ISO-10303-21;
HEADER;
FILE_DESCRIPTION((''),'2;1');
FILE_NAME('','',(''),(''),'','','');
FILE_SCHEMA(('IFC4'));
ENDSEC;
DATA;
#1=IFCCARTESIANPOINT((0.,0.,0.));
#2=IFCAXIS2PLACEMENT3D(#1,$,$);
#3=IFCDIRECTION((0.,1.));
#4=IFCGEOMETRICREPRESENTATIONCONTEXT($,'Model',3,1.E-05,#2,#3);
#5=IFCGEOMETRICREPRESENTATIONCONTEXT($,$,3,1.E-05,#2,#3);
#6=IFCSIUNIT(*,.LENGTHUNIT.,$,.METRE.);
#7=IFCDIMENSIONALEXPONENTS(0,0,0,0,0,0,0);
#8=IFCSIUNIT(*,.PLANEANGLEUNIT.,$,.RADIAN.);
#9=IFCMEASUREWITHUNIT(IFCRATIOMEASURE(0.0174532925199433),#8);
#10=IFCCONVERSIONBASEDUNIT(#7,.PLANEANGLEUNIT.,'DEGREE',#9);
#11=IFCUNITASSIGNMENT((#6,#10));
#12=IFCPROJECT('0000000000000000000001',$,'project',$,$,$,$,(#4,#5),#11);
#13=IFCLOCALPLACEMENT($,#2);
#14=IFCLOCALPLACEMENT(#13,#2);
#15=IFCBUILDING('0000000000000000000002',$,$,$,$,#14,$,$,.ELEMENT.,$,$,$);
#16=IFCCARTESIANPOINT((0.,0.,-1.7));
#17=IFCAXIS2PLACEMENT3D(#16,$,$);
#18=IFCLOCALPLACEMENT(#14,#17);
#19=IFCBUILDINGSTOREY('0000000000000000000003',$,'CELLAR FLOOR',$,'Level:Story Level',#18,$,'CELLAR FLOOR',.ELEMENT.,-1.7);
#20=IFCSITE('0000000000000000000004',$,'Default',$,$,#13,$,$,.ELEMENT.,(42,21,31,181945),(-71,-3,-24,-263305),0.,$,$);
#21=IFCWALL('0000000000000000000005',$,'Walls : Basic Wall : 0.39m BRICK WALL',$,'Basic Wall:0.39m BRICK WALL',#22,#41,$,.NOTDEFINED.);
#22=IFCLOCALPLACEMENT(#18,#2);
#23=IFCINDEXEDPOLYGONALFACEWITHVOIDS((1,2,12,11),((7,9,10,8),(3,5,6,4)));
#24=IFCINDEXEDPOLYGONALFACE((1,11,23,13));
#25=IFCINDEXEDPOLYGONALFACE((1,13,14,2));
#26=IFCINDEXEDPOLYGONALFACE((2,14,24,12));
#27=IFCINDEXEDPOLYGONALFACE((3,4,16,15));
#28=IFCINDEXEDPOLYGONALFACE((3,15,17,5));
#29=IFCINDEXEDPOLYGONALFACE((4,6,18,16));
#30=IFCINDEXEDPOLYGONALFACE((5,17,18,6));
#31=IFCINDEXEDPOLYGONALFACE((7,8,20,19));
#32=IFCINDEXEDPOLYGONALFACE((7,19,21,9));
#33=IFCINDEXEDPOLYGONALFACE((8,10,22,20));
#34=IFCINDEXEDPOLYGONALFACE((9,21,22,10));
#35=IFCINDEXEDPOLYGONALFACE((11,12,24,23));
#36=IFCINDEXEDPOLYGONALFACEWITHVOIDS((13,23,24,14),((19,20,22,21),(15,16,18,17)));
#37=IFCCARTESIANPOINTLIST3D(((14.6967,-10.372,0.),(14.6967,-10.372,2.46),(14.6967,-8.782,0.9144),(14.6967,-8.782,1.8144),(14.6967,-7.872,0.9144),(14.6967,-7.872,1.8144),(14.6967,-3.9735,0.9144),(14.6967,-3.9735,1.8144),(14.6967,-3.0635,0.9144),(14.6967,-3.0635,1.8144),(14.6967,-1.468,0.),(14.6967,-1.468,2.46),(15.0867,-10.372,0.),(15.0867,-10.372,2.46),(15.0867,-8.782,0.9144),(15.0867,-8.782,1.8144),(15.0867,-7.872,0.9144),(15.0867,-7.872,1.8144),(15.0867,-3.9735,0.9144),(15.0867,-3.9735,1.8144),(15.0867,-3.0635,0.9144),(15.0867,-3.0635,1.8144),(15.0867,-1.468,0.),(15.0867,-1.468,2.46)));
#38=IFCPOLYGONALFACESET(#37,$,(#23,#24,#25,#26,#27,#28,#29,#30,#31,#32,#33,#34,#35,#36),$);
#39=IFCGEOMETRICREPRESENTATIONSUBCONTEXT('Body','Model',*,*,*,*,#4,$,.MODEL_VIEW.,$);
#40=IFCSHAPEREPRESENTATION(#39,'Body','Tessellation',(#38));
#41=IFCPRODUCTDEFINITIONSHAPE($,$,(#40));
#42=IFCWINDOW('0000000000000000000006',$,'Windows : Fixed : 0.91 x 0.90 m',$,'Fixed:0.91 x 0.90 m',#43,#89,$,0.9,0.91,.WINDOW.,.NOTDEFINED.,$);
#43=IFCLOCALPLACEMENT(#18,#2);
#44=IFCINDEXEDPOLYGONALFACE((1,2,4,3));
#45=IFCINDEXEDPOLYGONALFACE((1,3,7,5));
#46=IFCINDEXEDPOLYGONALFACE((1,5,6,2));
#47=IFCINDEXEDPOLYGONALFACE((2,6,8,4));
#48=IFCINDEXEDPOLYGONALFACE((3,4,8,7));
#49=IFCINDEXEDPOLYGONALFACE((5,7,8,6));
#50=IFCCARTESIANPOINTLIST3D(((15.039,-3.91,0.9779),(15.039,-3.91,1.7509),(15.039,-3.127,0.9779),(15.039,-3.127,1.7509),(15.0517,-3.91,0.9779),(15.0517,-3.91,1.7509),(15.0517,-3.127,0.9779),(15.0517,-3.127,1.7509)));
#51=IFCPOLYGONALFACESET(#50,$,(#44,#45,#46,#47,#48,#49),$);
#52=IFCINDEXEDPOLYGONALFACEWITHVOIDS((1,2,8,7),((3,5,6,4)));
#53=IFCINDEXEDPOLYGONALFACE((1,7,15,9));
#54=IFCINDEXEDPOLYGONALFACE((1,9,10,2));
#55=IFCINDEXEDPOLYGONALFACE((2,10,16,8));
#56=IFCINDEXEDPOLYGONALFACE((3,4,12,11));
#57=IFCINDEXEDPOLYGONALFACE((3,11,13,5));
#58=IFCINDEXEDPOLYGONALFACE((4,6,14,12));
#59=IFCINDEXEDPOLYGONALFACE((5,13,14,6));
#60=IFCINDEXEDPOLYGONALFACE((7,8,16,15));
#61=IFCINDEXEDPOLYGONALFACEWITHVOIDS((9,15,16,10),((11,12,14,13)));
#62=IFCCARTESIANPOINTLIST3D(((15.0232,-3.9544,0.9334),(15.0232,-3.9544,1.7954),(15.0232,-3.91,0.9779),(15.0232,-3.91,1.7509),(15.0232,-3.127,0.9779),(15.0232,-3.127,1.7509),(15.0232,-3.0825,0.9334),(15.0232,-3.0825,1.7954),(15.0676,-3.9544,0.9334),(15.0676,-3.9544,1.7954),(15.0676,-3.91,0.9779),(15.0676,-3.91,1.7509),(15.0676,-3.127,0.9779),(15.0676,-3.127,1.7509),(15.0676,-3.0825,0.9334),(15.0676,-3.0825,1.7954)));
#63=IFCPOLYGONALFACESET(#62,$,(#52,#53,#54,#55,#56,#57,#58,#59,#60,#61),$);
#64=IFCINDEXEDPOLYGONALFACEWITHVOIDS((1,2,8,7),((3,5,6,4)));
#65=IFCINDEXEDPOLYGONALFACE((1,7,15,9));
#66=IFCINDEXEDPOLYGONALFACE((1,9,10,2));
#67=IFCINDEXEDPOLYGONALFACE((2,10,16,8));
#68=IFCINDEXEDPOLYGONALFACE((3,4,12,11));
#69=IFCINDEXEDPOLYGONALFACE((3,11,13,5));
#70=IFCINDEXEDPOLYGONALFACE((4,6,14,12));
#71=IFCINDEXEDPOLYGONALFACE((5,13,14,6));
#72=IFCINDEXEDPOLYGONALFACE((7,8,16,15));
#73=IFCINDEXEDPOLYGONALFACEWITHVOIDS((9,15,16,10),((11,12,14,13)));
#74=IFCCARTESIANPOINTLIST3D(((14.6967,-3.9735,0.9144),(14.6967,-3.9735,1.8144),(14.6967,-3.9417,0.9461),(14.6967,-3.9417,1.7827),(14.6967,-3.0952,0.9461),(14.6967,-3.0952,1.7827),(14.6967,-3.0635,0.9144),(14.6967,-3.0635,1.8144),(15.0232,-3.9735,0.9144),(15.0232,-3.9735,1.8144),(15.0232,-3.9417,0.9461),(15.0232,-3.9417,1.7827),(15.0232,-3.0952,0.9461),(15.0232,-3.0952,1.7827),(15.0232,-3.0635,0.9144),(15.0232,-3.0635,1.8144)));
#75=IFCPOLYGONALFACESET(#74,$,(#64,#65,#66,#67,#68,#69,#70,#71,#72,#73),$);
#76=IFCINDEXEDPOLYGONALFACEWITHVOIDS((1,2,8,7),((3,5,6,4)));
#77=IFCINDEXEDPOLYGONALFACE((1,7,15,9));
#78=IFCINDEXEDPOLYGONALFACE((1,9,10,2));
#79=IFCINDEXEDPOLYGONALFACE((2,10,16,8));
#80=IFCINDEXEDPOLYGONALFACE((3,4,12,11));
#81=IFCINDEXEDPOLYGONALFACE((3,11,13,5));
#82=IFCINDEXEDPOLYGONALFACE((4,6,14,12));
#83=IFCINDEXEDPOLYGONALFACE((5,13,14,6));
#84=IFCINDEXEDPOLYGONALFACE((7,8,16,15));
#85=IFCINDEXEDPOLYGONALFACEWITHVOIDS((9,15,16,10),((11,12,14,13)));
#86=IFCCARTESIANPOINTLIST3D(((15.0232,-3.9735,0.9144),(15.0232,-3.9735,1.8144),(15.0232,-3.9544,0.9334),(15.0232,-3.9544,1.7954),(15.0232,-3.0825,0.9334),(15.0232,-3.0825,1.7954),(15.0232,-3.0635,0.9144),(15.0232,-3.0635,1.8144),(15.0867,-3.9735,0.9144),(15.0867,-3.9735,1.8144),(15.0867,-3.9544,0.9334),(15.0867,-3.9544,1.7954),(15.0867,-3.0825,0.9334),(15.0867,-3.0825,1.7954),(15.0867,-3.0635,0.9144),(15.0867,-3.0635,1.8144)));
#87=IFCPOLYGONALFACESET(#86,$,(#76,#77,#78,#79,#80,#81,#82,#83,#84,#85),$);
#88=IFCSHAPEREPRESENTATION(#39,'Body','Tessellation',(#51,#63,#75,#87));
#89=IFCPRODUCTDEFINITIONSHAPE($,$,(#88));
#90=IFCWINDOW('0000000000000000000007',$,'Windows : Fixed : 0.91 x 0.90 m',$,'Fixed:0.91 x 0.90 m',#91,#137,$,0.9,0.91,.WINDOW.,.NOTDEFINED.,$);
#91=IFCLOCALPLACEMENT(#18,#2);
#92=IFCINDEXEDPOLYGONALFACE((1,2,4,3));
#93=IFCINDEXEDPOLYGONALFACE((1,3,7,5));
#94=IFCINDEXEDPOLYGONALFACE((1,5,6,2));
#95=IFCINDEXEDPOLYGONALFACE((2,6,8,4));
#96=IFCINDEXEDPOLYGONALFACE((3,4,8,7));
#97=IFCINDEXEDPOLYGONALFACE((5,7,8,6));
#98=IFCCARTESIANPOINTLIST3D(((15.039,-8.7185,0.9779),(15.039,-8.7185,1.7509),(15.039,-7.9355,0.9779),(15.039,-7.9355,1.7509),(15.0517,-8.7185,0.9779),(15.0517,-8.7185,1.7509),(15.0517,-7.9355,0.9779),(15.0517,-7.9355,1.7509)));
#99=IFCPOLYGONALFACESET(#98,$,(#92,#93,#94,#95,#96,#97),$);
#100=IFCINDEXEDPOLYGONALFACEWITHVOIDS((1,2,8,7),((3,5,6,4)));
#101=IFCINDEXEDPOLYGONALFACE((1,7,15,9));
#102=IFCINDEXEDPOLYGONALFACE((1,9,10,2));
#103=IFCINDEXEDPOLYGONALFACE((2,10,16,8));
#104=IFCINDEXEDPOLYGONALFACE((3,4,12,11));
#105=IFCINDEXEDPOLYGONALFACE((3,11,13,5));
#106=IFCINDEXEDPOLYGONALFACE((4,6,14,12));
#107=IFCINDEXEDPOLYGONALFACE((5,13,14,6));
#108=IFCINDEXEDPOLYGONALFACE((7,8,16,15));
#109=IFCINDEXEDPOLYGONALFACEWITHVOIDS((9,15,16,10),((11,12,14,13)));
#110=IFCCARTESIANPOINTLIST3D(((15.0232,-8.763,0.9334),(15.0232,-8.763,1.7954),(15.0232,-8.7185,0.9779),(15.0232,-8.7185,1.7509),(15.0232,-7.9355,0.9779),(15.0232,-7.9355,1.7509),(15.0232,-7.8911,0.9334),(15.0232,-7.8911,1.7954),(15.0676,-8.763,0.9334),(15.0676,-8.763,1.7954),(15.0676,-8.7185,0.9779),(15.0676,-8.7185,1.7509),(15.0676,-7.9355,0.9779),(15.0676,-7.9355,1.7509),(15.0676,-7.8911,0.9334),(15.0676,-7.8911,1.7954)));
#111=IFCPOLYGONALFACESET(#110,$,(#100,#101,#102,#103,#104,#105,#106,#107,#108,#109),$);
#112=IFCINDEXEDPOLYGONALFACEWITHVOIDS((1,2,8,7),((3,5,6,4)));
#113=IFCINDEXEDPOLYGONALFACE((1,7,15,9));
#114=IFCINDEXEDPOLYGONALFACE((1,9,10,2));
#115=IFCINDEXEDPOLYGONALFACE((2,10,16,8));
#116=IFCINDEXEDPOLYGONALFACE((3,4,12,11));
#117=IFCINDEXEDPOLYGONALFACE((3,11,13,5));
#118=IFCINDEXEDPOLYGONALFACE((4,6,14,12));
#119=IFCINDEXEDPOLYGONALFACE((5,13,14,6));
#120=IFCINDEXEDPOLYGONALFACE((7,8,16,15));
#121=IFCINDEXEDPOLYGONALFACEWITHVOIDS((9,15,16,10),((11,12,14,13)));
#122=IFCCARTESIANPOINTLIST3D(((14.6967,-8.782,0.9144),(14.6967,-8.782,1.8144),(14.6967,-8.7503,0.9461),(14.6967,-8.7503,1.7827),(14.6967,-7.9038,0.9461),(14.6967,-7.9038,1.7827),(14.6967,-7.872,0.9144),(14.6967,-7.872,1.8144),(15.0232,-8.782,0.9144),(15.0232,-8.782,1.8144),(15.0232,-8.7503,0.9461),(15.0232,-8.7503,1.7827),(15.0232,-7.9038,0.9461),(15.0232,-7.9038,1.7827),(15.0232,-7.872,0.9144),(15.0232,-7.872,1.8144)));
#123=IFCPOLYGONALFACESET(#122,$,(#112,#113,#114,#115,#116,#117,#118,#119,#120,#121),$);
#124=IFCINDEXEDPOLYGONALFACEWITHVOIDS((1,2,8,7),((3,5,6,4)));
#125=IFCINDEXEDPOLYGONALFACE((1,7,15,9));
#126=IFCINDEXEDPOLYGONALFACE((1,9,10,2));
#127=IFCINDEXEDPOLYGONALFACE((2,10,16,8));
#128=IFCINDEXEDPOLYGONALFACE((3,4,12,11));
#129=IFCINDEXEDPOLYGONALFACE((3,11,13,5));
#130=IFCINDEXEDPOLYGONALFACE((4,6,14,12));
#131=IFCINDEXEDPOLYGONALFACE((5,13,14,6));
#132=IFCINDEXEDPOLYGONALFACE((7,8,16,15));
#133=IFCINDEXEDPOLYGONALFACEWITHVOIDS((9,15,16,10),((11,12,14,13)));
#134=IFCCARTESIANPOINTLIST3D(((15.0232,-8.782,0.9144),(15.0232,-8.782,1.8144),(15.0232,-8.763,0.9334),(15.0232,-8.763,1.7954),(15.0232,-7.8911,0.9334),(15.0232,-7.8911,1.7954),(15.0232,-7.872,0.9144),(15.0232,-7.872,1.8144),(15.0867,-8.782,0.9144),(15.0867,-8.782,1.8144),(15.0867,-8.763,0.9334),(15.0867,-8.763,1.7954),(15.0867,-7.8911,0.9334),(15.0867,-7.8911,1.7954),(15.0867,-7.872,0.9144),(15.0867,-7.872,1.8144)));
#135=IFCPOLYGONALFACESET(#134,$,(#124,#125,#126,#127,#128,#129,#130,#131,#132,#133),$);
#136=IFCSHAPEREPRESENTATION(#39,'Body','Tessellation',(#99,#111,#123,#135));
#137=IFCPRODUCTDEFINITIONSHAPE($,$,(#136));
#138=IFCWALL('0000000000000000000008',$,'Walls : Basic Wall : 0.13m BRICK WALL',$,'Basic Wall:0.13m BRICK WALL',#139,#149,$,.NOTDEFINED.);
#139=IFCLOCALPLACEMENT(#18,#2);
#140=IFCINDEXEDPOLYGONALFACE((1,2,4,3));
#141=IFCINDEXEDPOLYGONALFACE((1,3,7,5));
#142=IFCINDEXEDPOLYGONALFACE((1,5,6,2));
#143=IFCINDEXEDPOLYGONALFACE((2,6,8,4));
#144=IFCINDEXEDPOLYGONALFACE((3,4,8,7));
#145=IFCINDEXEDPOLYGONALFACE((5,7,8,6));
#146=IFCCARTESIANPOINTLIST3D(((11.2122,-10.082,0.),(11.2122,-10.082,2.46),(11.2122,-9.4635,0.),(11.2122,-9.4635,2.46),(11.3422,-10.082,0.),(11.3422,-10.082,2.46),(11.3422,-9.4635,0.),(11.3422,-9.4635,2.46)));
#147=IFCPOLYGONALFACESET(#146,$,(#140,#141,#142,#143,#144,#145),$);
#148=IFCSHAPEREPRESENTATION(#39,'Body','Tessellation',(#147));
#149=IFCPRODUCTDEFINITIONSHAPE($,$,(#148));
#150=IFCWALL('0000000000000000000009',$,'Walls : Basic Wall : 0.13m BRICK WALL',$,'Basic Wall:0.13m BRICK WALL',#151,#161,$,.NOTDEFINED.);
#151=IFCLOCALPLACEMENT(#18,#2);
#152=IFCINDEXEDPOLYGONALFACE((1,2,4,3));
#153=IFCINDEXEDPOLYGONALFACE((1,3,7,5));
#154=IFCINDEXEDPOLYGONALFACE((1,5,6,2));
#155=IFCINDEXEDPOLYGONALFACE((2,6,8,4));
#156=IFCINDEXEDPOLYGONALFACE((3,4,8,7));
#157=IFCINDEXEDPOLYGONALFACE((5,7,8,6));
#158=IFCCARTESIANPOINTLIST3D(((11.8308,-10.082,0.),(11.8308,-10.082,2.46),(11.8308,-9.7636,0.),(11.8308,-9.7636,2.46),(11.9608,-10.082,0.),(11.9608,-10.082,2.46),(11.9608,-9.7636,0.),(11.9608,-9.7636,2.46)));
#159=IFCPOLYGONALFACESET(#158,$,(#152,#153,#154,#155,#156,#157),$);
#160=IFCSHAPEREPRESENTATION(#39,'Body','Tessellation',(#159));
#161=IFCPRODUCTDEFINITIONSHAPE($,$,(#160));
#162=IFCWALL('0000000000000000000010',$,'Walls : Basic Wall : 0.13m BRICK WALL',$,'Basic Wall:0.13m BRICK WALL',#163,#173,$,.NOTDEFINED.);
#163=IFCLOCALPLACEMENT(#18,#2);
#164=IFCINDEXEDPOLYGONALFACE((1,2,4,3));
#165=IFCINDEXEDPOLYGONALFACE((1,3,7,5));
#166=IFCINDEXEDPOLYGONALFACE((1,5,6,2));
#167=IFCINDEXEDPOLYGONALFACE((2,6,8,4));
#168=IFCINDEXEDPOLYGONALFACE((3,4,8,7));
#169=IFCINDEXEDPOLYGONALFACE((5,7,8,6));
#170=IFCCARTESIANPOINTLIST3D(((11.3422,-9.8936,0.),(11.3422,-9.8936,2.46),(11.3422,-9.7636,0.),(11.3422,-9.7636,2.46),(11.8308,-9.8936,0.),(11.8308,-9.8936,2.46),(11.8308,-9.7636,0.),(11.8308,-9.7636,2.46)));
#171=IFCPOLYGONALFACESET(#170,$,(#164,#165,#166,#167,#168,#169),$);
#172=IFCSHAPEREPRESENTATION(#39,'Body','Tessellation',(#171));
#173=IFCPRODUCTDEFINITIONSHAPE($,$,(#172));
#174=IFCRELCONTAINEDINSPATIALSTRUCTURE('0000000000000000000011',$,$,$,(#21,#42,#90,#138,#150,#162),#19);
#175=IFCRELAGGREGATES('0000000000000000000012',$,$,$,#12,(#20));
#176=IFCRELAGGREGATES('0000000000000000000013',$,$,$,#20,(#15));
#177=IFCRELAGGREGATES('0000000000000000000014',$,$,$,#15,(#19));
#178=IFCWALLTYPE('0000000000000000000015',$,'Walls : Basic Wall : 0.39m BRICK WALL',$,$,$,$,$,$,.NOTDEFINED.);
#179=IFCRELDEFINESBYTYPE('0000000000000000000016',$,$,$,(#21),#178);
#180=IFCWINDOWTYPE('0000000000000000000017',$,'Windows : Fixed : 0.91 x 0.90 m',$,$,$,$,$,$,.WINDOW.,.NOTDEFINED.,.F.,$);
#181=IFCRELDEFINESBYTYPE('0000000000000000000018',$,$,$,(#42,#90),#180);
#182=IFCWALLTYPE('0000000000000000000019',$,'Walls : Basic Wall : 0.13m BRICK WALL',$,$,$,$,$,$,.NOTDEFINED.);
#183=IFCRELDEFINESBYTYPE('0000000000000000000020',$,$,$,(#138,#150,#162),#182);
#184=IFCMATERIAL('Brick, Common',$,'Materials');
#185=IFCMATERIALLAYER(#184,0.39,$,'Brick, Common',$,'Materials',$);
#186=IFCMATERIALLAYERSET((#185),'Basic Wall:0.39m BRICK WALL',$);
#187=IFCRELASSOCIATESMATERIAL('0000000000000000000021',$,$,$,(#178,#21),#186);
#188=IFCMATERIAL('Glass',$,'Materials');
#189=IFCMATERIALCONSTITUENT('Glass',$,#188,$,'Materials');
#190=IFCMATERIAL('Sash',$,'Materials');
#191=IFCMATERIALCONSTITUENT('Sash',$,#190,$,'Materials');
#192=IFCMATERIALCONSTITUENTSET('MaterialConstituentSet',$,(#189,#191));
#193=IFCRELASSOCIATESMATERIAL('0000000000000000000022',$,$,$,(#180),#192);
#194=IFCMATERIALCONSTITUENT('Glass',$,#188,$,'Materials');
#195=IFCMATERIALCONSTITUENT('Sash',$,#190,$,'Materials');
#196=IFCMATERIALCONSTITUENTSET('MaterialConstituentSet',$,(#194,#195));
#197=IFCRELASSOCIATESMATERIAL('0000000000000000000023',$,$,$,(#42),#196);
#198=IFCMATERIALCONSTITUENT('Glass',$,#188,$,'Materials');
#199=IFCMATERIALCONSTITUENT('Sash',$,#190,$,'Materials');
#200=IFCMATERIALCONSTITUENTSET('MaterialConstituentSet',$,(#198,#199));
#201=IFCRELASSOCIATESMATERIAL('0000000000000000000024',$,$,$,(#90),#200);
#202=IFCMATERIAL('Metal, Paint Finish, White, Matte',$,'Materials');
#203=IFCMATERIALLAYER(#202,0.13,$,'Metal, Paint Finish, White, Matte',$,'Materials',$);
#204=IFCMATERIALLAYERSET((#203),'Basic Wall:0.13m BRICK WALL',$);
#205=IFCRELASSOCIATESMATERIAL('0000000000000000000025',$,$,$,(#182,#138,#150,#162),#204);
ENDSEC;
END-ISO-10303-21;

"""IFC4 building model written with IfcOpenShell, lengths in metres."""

from ifc_helpers import new_model, entity, si_unit, converted_unit, direction, frame, frame_2d, origin, place, context, subcontext, project, spatial, polyline, rectangle, outline, extrude, source, transform, mapped, material, layer, layer_set, layer_usage, constituent, constituent_set, type_object, type_shapes, element, fill, save


model = new_model("IFC4")

# Units and contexts
model_context = context("Model", 3, precision=1e-05, world=origin(), true_north=direction((0.0, 1.0)))
context_of_model = context(None, 3, precision=1e-05, world=origin(), true_north=direction((0.0, 1.0)))
body_context = subcontext(model_context, "Body", "Model", "MODEL_VIEW")
ifc_project = project(units=[si_unit("LENGTHUNIT", "METRE"), converted_unit("PLANEANGLEUNIT", "DEGREE", entity("IfcRatioMeasure", 0.0174532925199433), si_unit("PLANEANGLEUNIT", "RADIAN"), dimensions=[0, 0, 0, 0, 0, 0, 0])], contexts=[model_context, context_of_model])

# Site, building, storey
site_placement = place(None, origin())
site = spatial("IfcSite", under=ifc_project, at=site_placement, Name="Default", CompositionType="ELEMENT", RefLatitude=(42, 21, 31, 181945), RefLongitude=(-71, -3, -24, -263305), RefElevation=0.0)
building_placement = place(site_placement, origin())
building = spatial("IfcBuilding", under=site, at=building_placement, CompositionType="ELEMENT")
storey_placement = place(building_placement, frame((0.0, 0.0, -1.7)))
storey = spatial("IfcBuildingStorey", under=building, at=storey_placement, Name="CELLAR FLOOR", ObjectType="Level:Story Level", LongName="CELLAR FLOOR", CompositionType="ELEMENT", Elevation=-1.7)

# Shared definitions
ifc_material_1 = material(Name="Metal, Paint Finish, White, Matte", Category="Materials")
ifc_material_2 = material(Name="Glass", Category="Materials")
ifc_material_3 = material(Name="Sash", Category="Materials")

# Wall, openings, windows
ifc_material_4 = material(Name="Brick, Common", Category="Materials")
ifc_layer_1 = layer(ifc_material_4, 0.39, Name="Brick, Common", Category="Materials")
ifc_layer_set_1 = layer_set([ifc_layer_1], Name="Basic Wall:0.39m BRICK WALL")
ifc_layer_usage_1 = layer_usage(ifc_layer_set_1, "AXIS2", "NEGATIVE", 0.195)
wall_type_1 = type_object("IfcWallType", Name="Walls : Basic Wall : 0.39m BRICK WALL", PredefinedType="NOTDEFINED", material=ifc_layer_set_1)
wall_1_placement = place(storey_placement, frame((14.8917, -10.372, 0.0), z_axis=(0.0, 0.0, 1.0), x_axis=(0.0, 1.0, 0.0)))
wall_1 = element("IfcWall", 1, at=wall_1_placement, inside=storey, type_object=wall_type_1, material=ifc_layer_usage_1, Name="Walls : Basic Wall : 0.39m BRICK WALL", ObjectType="Basic Wall:0.39m BRICK WALL", PredefinedType="NOTDEFINED", context=body_context, shape_type="SweptSolid", body=[
    extrude(rectangle(XDim=8.904, YDim=0.39, at=frame_2d((4.452, 0.0), x_axis=(-1.0, 0.0))), origin(), (0.0, 0.0, 1.0), 2.46),
])
opening_1_placement = place(wall_1_placement, frame((7.3085, 0.195, 0.9144)))
opening_1 = element("IfcOpeningElement", 2, at=opening_1_placement, cuts=wall_1, ObjectType="Opening", PredefinedType="OPENING", context=body_context, shape_type="SweptSolid", body=[
    extrude(rectangle(XDim=0.9, YDim=0.91, at=frame_2d((0.45, 0.455), x_axis=(-1.0, 0.0))), frame((0.0, 0.0, 0.0), z_axis=(0.0, -1.0, 0.0), x_axis=(0.0, 0.0, 1.0)), (0.0, 0.0, 1.0), 0.39),
])
opening_2_placement = place(wall_1_placement, frame((2.5, 0.195, 0.9144)))
opening_2 = element("IfcOpeningElement", 3, at=opening_2_placement, cuts=wall_1, ObjectType="Opening", PredefinedType="OPENING", context=body_context, shape_type="SweptSolid", body=[
    extrude(rectangle(XDim=0.9, YDim=0.91, at=frame_2d((0.45, 0.455), x_axis=(-1.0, 0.0))), frame((0.0, 0.0, 0.0), z_axis=(0.0, -1.0, 0.0), x_axis=(0.0, 0.0, 1.0)), (0.0, 0.0, 1.0), 0.39),
])
ifc_constituent_1 = constituent(ifc_material_2, Name="Glass", Category="Materials")
ifc_constituent_2 = constituent(ifc_material_3, Name="Sash", Category="Materials")
ifc_constituent_set_1 = constituent_set(constituents=[ifc_constituent_1, ifc_constituent_2], Name="MaterialConstituentSet")
ifc_constituent_3 = constituent(ifc_material_2, Name="Glass", Category="Materials")
ifc_constituent_4 = constituent(ifc_material_3, Name="Sash", Category="Materials")
ifc_constituent_set_2 = constituent_set(constituents=[ifc_constituent_3, ifc_constituent_4], Name="MaterialConstituentSet")
window_type_1 = type_object("IfcWindowType", Name="Windows : Fixed : 0.91 x 0.90 m", ParameterTakesPrecedence=False, PartitioningType="NOTDEFINED", PredefinedType="WINDOW", material=ifc_constituent_set_2)
shared_shape_1 = source(origin(), body_context, "Body", "SweptSolid", [
    extrude(rectangle(XDim=0.0127, YDim=0.783, at=frame_2d((0.0, 0.0), x_axis=(1.0, 0.0))), frame((0.455, 0.3487, 0.0635), z_axis=(0.0, 0.0, 1.0), x_axis=(0.0, 1.0, 0.0)), (0.0, 0.0, 1.0), 0.773),
    extrude(outline(polyline([(-0.4359, -0.431), (0.4359, -0.431), (0.4359, 0.431), (-0.4359, 0.431), (-0.4359, -0.431)]), holes=[polyline([(-0.3915, -0.3865), (-0.3915, 0.3865), (0.3915, 0.3865), (0.3915, -0.3865), (-0.3915, -0.3865)])]), frame((0.455, 0.3265, 0.45), z_axis=(0.0, 1.0, 0.0), x_axis=(1.0, 0.0, 0.0)), (0.0, 0.0, 1.0), 0.0445),
    extrude(outline(polyline([(-0.455, -0.45), (0.455, -0.45), (0.455, 0.45), (-0.455, 0.45), (-0.455, -0.45)]), holes=[polyline([(-0.4233, -0.4182), (-0.4233, 0.4183), (0.4232, 0.4183), (0.4232, -0.4182), (-0.4233, -0.4182)])]), frame((0.455, 0.0, 0.45), z_axis=(0.0, 1.0, 0.0), x_axis=(1.0, 0.0, 0.0)), (0.0, 0.0, 1.0), 0.3265),
    extrude(outline(polyline([(-0.45, -0.455), (0.45, -0.455), (0.45, 0.455), (-0.45, 0.455), (-0.45, -0.455)]), holes=[polyline([(-0.4309, -0.4359), (-0.4309, 0.436), (0.431, 0.436), (0.431, -0.4359), (-0.4309, -0.4359)])]), frame((0.455, 0.3265, 0.45), z_axis=(0.0, 1.0, 0.0), x_axis=(0.0, 0.0, -1.0)), (0.0, 0.0, 1.0), 0.0635),
])
type_shapes(window_type_1, [shared_shape_1])
window_1_placement = place(opening_1_placement, frame((0.0, 0.0, 0.0), z_axis=(0.0, 0.0, 1.0), x_axis=(-1.0, 0.0, 0.0)))
window_1 = element("IfcWindow", 4, at=window_1_placement, inside=storey, type_object=window_type_1, material=ifc_constituent_set_1, Name="Windows : Fixed : 0.91 x 0.90 m", ObjectType="Fixed:0.91 x 0.90 m", OverallHeight=0.9, OverallWidth=0.91, PartitioningType="NOTDEFINED", PredefinedType="WINDOW", context=body_context, shape_type="MappedRepresentation", body=[
    mapped(shared_shape_1, transform((0.0, 0.0, 0.0), scale=1.0)),
])
fill(opening_1, window_1)
ifc_constituent_5 = constituent(ifc_material_2, Name="Glass", Category="Materials")
ifc_constituent_6 = constituent(ifc_material_3, Name="Sash", Category="Materials")
ifc_constituent_set_3 = constituent_set(constituents=[ifc_constituent_5, ifc_constituent_6], Name="MaterialConstituentSet")
window_2_placement = place(opening_2_placement, frame((0.0, 0.0, 0.0), z_axis=(0.0, 0.0, 1.0), x_axis=(-1.0, 0.0, 0.0)))
window_2 = element("IfcWindow", 5, at=window_2_placement, inside=storey, type_object=window_type_1, material=ifc_constituent_set_3, Name="Windows : Fixed : 0.91 x 0.90 m", ObjectType="Fixed:0.91 x 0.90 m", OverallHeight=0.9, OverallWidth=0.91, PartitioningType="NOTDEFINED", PredefinedType="WINDOW", context=body_context, shape_type="MappedRepresentation", body=[
    mapped(shared_shape_1, transform((0.0, 0.0, 0.0), scale=1.0)),
])
fill(opening_2, window_2)

# Walls
ifc_layer_2 = layer(ifc_material_1, 0.13, Name="Metal, Paint Finish, White, Matte", Category="Materials")
ifc_layer_set_2 = layer_set([ifc_layer_2], Name="Basic Wall:0.13m BRICK WALL")
ifc_layer_usage_2 = layer_usage(ifc_layer_set_2, "AXIS2", "NEGATIVE", 0.065)
wall_type_2 = type_object("IfcWallType", Name="Walls : Basic Wall : 0.13m BRICK WALL", PredefinedType="NOTDEFINED", material=ifc_layer_set_2)
wall_2_placement = place(storey_placement, frame((11.2772, -10.082, 0.0), z_axis=(0.0, 0.0, 1.0), x_axis=(0.0, 1.0, 0.0)))
element("IfcWall", 6, at=wall_2_placement, inside=storey, type_object=wall_type_2, material=ifc_layer_usage_2, Name="Walls : Basic Wall : 0.13m BRICK WALL", ObjectType="Basic Wall:0.13m BRICK WALL", PredefinedType="NOTDEFINED", context=body_context, shape_type="SweptSolid", body=[
    extrude(rectangle(XDim=0.6185, YDim=0.13, at=frame_2d((0.3092, 0.0), x_axis=(-1.0, 0.0))), origin(), (0.0, 0.0, 1.0), 2.46),
])
ifc_layer_usage_3 = layer_usage(ifc_layer_set_2, "AXIS2", "NEGATIVE", 0.065)
wall_3_placement = place(storey_placement, frame((11.8958, -9.7636, 0.0), z_axis=(0.0, 0.0, 1.0), x_axis=(0.0, -1.0, 0.0)))
element("IfcWall", 7, at=wall_3_placement, inside=storey, type_object=wall_type_2, material=ifc_layer_usage_3, Name="Walls : Basic Wall : 0.13m BRICK WALL", ObjectType="Basic Wall:0.13m BRICK WALL", PredefinedType="NOTDEFINED", context=body_context, shape_type="SweptSolid", body=[
    extrude(rectangle(XDim=0.3184, YDim=0.13, at=frame_2d((0.1592, 0.0), x_axis=(-1.0, 0.0))), origin(), (0.0, 0.0, 1.0), 2.46),
])
ifc_layer_usage_4 = layer_usage(ifc_layer_set_2, "AXIS2", "NEGATIVE", 0.065)
wall_4_placement = place(storey_placement, frame((11.3422, -9.8286, 0.0)))
element("IfcWall", 8, at=wall_4_placement, inside=storey, type_object=wall_type_2, material=ifc_layer_usage_4, Name="Walls : Basic Wall : 0.13m BRICK WALL", ObjectType="Basic Wall:0.13m BRICK WALL", PredefinedType="NOTDEFINED", context=body_context, shape_type="SweptSolid", body=[
    extrude(rectangle(XDim=0.4886, YDim=0.13, at=frame_2d((0.2443, 0.0), x_axis=(-1.0, 0.0))), origin(), (0.0, 0.0, 1.0), 2.46),
])

save(model, "model.ifc")
